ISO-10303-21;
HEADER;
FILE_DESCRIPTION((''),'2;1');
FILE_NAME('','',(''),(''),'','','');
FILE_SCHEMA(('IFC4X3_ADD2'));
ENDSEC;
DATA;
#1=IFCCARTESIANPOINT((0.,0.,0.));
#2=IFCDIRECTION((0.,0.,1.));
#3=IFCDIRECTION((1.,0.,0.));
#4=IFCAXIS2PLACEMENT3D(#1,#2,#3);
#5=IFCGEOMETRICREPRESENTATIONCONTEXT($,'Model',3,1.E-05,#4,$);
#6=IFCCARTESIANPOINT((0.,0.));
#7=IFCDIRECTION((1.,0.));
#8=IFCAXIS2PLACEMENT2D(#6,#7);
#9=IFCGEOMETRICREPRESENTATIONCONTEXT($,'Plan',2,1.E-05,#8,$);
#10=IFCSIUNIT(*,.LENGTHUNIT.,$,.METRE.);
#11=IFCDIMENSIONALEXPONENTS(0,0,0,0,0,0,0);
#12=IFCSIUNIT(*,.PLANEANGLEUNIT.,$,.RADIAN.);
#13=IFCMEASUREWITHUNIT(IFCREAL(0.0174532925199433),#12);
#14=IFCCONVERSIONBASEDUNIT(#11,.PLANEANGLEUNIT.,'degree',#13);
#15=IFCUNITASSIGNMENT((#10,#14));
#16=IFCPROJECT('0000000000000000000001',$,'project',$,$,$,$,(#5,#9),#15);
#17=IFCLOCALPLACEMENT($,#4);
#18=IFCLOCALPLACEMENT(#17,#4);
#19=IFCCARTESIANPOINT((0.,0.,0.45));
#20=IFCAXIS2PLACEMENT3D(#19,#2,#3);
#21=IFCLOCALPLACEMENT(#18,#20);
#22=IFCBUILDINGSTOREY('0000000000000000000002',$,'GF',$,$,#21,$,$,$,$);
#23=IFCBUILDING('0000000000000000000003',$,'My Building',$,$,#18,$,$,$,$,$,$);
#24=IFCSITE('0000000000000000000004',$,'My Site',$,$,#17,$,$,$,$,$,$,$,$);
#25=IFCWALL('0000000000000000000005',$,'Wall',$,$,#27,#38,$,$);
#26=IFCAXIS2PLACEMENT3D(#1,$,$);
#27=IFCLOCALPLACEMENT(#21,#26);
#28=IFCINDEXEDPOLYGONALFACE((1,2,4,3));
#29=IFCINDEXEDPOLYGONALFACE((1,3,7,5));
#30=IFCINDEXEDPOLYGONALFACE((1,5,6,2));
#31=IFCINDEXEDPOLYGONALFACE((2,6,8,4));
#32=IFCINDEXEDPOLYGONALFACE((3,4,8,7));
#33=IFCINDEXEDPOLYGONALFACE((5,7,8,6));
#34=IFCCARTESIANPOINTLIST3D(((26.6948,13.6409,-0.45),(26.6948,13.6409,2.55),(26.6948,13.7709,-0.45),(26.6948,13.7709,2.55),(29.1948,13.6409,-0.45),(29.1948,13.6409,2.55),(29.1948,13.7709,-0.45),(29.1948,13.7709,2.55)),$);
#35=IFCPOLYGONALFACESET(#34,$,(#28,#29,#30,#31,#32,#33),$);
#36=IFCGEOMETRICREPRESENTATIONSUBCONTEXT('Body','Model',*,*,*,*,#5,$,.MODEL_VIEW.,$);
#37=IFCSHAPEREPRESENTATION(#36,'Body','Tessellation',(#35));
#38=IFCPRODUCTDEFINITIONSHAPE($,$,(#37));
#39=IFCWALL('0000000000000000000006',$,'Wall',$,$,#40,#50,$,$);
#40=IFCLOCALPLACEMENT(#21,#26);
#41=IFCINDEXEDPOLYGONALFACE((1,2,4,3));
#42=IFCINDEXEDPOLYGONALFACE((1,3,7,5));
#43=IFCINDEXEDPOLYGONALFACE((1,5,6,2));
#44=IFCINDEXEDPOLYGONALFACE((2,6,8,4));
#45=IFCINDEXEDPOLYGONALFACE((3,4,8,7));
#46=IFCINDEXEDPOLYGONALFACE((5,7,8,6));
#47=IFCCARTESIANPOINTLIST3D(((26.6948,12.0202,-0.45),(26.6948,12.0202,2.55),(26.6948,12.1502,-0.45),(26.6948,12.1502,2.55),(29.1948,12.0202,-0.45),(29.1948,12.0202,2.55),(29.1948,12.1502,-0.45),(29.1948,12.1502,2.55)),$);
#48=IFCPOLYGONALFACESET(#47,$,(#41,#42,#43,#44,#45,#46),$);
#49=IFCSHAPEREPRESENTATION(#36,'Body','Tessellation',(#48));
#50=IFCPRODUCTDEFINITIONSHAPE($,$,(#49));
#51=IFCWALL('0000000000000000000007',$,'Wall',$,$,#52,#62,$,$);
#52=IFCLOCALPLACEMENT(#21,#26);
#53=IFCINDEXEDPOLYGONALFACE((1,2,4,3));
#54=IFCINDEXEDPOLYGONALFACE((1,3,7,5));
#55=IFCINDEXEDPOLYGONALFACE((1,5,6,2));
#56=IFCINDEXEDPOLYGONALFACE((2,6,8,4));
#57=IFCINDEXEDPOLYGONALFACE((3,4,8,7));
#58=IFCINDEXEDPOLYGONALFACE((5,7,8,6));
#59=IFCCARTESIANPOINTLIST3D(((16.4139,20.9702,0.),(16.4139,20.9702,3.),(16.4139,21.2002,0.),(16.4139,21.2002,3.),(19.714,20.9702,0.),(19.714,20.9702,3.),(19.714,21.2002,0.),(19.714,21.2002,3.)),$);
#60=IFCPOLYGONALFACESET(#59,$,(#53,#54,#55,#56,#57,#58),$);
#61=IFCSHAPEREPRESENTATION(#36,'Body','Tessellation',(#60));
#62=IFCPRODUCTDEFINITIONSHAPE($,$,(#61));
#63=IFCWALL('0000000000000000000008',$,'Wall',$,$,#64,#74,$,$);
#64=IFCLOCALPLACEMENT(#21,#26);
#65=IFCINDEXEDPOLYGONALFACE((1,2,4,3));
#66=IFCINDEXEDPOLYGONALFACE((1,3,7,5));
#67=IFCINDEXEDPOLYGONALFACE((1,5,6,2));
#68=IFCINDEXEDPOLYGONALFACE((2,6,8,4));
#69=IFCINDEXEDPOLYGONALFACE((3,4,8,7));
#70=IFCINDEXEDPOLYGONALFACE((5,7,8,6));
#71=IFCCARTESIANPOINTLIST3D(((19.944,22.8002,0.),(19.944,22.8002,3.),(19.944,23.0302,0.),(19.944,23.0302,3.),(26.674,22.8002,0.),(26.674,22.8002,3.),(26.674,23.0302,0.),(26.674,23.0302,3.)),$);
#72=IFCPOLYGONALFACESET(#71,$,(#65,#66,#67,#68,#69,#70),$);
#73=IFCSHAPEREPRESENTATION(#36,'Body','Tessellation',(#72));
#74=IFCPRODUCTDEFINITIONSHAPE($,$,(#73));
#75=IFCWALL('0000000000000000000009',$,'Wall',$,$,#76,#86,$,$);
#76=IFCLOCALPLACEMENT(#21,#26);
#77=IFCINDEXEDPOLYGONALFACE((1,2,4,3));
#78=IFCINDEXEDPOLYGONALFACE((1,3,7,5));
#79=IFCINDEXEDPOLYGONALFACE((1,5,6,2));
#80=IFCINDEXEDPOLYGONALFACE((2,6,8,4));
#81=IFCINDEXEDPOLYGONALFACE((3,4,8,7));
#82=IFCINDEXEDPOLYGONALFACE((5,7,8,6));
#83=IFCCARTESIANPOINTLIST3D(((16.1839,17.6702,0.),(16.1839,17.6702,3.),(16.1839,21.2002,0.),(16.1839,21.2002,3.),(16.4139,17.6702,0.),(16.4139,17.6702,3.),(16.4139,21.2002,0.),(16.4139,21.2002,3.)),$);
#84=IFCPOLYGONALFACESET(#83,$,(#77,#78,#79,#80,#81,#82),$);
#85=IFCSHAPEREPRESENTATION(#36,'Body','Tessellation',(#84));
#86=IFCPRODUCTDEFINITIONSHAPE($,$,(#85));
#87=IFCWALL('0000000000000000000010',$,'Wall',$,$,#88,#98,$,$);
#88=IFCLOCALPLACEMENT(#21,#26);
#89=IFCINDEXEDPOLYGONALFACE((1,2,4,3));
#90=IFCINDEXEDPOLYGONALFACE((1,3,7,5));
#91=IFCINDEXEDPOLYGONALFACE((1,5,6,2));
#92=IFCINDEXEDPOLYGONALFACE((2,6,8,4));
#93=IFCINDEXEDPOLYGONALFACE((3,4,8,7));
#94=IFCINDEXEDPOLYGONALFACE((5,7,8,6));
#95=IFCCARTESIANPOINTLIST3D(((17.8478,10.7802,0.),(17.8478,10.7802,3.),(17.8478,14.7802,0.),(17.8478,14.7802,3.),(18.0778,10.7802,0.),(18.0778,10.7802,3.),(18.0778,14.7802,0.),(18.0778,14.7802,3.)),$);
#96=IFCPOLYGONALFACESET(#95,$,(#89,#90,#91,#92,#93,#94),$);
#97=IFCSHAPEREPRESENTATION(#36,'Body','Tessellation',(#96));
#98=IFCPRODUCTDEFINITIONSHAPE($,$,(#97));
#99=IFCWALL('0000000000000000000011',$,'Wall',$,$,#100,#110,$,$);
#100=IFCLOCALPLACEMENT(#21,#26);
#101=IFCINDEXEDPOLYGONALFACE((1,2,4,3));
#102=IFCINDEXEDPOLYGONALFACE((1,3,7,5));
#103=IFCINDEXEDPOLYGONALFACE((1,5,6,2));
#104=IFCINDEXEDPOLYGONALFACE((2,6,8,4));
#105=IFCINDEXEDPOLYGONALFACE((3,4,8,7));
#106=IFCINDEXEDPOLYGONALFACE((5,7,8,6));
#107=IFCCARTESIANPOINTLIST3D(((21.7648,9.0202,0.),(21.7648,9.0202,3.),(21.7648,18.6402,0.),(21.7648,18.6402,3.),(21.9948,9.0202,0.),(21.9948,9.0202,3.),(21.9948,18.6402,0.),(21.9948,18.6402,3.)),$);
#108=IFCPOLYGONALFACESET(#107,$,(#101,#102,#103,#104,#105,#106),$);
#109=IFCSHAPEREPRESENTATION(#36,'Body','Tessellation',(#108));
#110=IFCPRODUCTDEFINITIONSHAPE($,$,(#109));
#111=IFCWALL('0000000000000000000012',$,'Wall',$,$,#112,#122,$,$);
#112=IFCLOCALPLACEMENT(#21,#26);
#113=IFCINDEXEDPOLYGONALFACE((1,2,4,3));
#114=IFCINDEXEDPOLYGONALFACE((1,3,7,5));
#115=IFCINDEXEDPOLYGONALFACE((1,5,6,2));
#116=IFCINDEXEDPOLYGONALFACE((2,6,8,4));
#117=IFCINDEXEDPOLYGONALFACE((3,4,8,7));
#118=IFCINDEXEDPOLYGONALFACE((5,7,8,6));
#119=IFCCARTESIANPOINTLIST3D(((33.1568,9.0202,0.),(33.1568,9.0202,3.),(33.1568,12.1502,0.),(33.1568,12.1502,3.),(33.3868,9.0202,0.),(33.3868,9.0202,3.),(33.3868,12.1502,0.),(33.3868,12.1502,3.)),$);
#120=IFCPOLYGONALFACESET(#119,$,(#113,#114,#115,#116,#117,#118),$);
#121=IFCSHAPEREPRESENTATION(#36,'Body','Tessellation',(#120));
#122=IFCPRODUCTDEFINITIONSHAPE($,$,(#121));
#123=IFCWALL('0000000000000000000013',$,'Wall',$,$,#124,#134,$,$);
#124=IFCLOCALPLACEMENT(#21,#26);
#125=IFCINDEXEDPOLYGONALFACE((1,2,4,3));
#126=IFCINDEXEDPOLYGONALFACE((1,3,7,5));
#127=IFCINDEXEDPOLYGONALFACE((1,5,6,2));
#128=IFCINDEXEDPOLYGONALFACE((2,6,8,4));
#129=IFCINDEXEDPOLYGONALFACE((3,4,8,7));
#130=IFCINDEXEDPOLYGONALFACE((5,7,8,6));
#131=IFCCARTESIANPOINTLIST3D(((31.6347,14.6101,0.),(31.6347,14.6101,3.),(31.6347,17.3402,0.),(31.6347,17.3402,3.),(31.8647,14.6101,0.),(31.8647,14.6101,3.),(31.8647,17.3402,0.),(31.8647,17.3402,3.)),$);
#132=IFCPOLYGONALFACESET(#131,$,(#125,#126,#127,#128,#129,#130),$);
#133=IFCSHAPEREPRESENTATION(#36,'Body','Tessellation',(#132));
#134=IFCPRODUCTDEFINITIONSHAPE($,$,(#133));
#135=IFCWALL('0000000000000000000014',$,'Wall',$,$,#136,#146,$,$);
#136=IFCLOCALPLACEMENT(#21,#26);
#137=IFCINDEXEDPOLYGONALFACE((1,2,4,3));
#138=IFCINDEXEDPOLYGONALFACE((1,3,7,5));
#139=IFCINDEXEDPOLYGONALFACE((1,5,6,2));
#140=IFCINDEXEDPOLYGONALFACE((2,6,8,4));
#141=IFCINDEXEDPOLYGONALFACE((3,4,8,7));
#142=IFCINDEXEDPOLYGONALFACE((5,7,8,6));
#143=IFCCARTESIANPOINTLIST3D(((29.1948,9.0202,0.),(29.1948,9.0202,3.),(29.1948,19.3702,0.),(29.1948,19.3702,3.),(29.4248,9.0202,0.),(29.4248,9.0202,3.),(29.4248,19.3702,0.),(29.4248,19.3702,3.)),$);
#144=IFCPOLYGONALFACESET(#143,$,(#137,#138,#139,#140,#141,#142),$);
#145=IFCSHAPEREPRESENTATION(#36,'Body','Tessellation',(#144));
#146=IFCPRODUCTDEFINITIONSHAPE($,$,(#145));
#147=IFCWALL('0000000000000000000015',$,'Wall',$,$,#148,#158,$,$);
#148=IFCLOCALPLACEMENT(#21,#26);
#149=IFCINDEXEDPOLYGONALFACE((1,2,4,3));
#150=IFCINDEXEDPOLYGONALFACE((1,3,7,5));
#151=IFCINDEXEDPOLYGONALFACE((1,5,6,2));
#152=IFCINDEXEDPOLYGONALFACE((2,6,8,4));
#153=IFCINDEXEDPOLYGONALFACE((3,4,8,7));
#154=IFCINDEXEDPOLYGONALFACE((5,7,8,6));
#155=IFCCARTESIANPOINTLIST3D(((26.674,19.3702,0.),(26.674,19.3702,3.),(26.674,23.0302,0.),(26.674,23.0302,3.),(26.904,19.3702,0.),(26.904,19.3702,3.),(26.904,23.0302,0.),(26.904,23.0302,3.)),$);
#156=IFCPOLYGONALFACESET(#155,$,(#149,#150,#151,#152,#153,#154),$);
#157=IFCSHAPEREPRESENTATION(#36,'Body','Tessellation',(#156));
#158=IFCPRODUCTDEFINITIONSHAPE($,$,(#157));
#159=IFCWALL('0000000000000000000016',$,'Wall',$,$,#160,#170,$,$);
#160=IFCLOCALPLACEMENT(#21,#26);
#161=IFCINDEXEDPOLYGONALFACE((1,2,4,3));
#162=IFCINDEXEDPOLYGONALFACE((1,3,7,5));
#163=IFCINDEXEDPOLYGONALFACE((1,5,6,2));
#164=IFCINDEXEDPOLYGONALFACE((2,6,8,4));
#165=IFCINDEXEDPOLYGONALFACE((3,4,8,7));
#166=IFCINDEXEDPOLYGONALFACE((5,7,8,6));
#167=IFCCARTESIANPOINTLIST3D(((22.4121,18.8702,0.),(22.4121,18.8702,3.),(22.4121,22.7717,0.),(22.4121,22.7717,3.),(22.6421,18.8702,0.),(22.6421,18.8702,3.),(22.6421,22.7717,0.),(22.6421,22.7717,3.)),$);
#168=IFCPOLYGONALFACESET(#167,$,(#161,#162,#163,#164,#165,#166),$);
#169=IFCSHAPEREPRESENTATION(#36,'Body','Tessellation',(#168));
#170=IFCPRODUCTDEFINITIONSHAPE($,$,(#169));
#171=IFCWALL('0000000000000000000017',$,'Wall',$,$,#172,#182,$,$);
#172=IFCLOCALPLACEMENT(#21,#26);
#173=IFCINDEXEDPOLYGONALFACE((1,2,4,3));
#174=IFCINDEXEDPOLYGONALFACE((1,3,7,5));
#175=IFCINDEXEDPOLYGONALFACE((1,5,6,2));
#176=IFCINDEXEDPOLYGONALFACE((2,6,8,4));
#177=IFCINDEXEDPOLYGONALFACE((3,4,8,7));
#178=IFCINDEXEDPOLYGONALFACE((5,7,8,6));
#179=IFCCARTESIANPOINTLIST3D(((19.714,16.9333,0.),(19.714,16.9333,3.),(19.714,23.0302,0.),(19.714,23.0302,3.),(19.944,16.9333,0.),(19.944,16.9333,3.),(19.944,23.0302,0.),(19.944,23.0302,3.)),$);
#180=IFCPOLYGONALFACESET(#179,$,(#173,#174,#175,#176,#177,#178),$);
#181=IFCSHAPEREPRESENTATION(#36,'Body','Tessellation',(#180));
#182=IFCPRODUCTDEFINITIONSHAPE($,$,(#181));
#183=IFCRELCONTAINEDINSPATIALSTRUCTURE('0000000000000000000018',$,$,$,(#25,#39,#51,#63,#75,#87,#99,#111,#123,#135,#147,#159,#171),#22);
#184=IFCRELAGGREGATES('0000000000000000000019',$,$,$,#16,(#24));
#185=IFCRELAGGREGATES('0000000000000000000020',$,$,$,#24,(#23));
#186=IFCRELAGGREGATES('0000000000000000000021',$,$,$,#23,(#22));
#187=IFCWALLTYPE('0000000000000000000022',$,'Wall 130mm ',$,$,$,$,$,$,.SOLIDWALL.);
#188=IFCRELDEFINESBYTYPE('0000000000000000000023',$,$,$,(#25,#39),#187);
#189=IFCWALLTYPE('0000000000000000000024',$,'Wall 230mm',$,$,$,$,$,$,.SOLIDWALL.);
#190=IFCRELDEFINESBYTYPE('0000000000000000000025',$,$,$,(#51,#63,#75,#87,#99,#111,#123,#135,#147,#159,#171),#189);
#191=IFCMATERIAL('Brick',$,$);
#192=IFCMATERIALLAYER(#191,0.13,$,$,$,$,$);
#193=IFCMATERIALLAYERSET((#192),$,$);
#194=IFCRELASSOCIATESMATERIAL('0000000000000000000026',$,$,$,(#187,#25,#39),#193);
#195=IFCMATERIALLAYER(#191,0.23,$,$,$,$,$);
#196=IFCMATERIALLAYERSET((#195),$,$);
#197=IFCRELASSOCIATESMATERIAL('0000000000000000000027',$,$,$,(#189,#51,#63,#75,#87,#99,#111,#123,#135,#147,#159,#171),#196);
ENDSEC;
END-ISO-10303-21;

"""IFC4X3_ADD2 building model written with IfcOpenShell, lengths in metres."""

from ifc_helpers import new_model, entity, si_unit, converted_unit, frame, origin_with_axes, origin_2d_with_axis, place, context, subcontext, project, spatial, indexed_curve, outline, extrude, material, layer, layer_set, layer_usage, type_object, element, save


model = new_model("IFC4X3_ADD2")

# Units and contexts
model_context = context("Model", 3, precision=1e-05, world=origin_with_axes())
plan_context = context("Plan", 2, precision=1e-05, world=origin_2d_with_axis())
body_context = subcontext(model_context, "Body", "Model", "MODEL_VIEW")
ifc_project = project(units=[si_unit("LENGTHUNIT", "METRE"), converted_unit("PLANEANGLEUNIT", "degree", entity("IfcReal", 0.0174532925199433), si_unit("PLANEANGLEUNIT", "RADIAN"), dimensions=[0, 0, 0, 0, 0, 0, 0])], contexts=[model_context, plan_context])

# Site, building, storey
site_placement = place(None, origin_with_axes())
site = spatial("IfcSite", under=ifc_project, at=site_placement, Name="My Site")
building_placement = place(site_placement, origin_with_axes())
building = spatial("IfcBuilding", under=site, at=building_placement, Name="My Building")
storey_placement = place(building_placement, frame((0.0, 0.0, 0.45), z_axis=(0.0, 0.0, 1.0), x_axis=(1.0, 0.0, 0.0)))
storey = spatial("IfcBuildingStorey", under=building, at=storey_placement, Name="GF")

# Walls
ifc_material_1 = material(Name="Brick")
ifc_layer_1 = layer(ifc_material_1, 0.13)
ifc_layer_set_1 = layer_set([ifc_layer_1])
ifc_layer_usage_1 = layer_usage(ifc_layer_set_1, "AXIS2", "POSITIVE", 0.0)
wall_type_1 = type_object("IfcWallType", Name="Wall 130mm ", PredefinedType="SOLIDWALL", material=ifc_layer_set_1)
wall_1_placement = place(storey_placement, frame((29.1948, 13.7709, -0.45), z_axis=(0.0, 0.0, 1.0), x_axis=(-1.0, 0.0, 0.0)))
element("IfcWall", 1, at=wall_1_placement, inside=storey, type_object=wall_type_1, material=ifc_layer_usage_1, Name="Wall", context=body_context, shape_type="SweptSolid", body=[
    extrude(outline(indexed_curve([(0.0, 0.0), (0.0, 0.13), (2.5, 0.13), (2.5, 0.0), (0.0, 0.0)], self_intersect=False)), origin_with_axes(), (0.0, 0.0, 1.0), 3.0),
])
ifc_layer_usage_2 = layer_usage(ifc_layer_set_1, "AXIS2", "POSITIVE", 0.0)
wall_2_placement = place(storey_placement, frame((29.1948, 12.1502, -0.45), z_axis=(0.0, 0.0, 1.0), x_axis=(-1.0, 0.0, 0.0)))
element("IfcWall", 2, at=wall_2_placement, inside=storey, type_object=wall_type_1, material=ifc_layer_usage_2, Name="Wall", context=body_context, shape_type="SweptSolid", body=[
    extrude(outline(indexed_curve([(0.0, 0.0), (0.0, 0.13), (2.5, 0.13), (2.5, 0.0), (0.0, 0.0)], self_intersect=False)), origin_with_axes(), (0.0, 0.0, 1.0), 3.0),
])
ifc_layer_2 = layer(ifc_material_1, 0.23)
ifc_layer_set_2 = layer_set([ifc_layer_2])
ifc_layer_usage_3 = layer_usage(ifc_layer_set_2, "AXIS2", "POSITIVE", 0.0)
wall_type_2 = type_object("IfcWallType", Name="Wall 230mm", PredefinedType="SOLIDWALL", material=ifc_layer_set_2)
wall_3_placement = place(storey_placement, frame((19.714, 21.2002, 0.0), z_axis=(0.0, 0.0, 1.0), x_axis=(-1.0, 0.0, 0.0)))
element("IfcWall", 3, at=wall_3_placement, inside=storey, type_object=wall_type_2, material=ifc_layer_usage_3, Name="Wall", context=body_context, shape_type="SweptSolid", body=[
    extrude(outline(indexed_curve([(0.0, 0.0), (0.0, 0.23), (3.3, 0.23), (3.3, 0.0), (0.0, 0.0)], self_intersect=False)), origin_with_axes(), (0.0, 0.0, 1.0), 3.0),
])
ifc_layer_usage_4 = layer_usage(ifc_layer_set_2, "AXIS2", "POSITIVE", 0.0)
wall_4_placement = place(storey_placement, frame((26.674, 23.0302, 0.0), z_axis=(0.0, 0.0, 1.0), x_axis=(-1.0, 0.0, 0.0)))
element("IfcWall", 4, at=wall_4_placement, inside=storey, type_object=wall_type_2, material=ifc_layer_usage_4, Name="Wall", context=body_context, shape_type="SweptSolid", body=[
    extrude(outline(indexed_curve([(0.0, 0.0), (0.0, 0.23), (6.73, 0.23), (6.73, 0.0), (0.0, 0.0)], self_intersect=False)), origin_with_axes(), (0.0, 0.0, 1.0), 3.0),
])
ifc_layer_usage_5 = layer_usage(ifc_layer_set_2, "AXIS2", "POSITIVE", 0.0)
wall_5_placement = place(storey_placement, frame((16.4139, 17.6702, 0.0), z_axis=(0.0, 0.0, 1.0), x_axis=(0.000001, 1.0, 0.0)))
element("IfcWall", 5, at=wall_5_placement, inside=storey, type_object=wall_type_2, material=ifc_layer_usage_5, Name="Wall", context=body_context, shape_type="SweptSolid", body=[
    extrude(outline(indexed_curve([(0.0, 0.0), (0.0, 0.23), (3.53, 0.23), (3.53, 0.0), (0.0, 0.0)], self_intersect=False)), origin_with_axes(), (0.0, 0.0, 1.0), 3.0),
])
ifc_layer_usage_6 = layer_usage(ifc_layer_set_2, "AXIS2", "POSITIVE", 0.0)
wall_6_placement = place(storey_placement, frame((18.0778, 10.7802, 0.0), z_axis=(0.0, 0.0, 1.0), x_axis=(0.000001, 1.0, 0.0)))
element("IfcWall", 6, at=wall_6_placement, inside=storey, type_object=wall_type_2, material=ifc_layer_usage_6, Name="Wall", context=body_context, shape_type="SweptSolid", body=[
    extrude(outline(indexed_curve([(0.0, 0.0), (0.0, 0.23), (4.0, 0.23), (4.0, 0.0), (0.0, 0.0)], self_intersect=False)), origin_with_axes(), (0.0, 0.0, 1.0), 3.0),
])
ifc_layer_usage_7 = layer_usage(ifc_layer_set_2, "AXIS2", "POSITIVE", 0.0)
wall_7_placement = place(storey_placement, frame((21.9948, 9.0202, 0.0), z_axis=(0.0, 0.0, 1.0), x_axis=(0.000001, 1.0, 0.0)))
element("IfcWall", 7, at=wall_7_placement, inside=storey, type_object=wall_type_2, material=ifc_layer_usage_7, Name="Wall", context=body_context, shape_type="SweptSolid", body=[
    extrude(outline(indexed_curve([(0.0, 0.0), (0.0, 0.23), (9.62, 0.23), (9.62, 0.0), (0.0, 0.0)], self_intersect=False)), origin_with_axes(), (0.0, 0.0, 1.0), 3.0),
])
ifc_layer_usage_8 = layer_usage(ifc_layer_set_2, "AXIS2", "POSITIVE", 0.0)
wall_8_placement = place(storey_placement, frame((33.3868, 9.0202, 0.0), z_axis=(0.0, 0.0, 1.0), x_axis=(0.000001, 1.0, 0.0)))
element("IfcWall", 8, at=wall_8_placement, inside=storey, type_object=wall_type_2, material=ifc_layer_usage_8, Name="Wall", context=body_context, shape_type="SweptSolid", body=[
    extrude(outline(indexed_curve([(0.0, 0.0), (0.0, 0.23), (3.13, 0.23), (3.13, 0.0), (0.0, 0.0)], self_intersect=False)), origin_with_axes(), (0.0, 0.0, 1.0), 3.0),
])
ifc_layer_usage_9 = layer_usage(ifc_layer_set_2, "AXIS2", "POSITIVE", 0.0)
wall_9_placement = place(storey_placement, frame((31.8647, 14.6101, 0.0), z_axis=(0.0, 0.0, 1.0), x_axis=(0.000001, 1.0, 0.0)))
element("IfcWall", 9, at=wall_9_placement, inside=storey, type_object=wall_type_2, material=ifc_layer_usage_9, Name="Wall", context=body_context, shape_type="SweptSolid", body=[
    extrude(outline(indexed_curve([(0.0, 0.0), (0.0, 0.23), (2.73, 0.23), (2.73, 0.0), (0.0, 0.0)], self_intersect=False)), origin_with_axes(), (0.0, 0.0, 1.0), 3.0),
])
ifc_layer_usage_10 = layer_usage(ifc_layer_set_2, "AXIS2", "POSITIVE", 0.0)
wall_10_placement = place(storey_placement, frame((29.4248, 9.0202, 0.0), z_axis=(0.0, 0.0, 1.0), x_axis=(0.000001, 1.0, 0.0)))
element("IfcWall", 10, at=wall_10_placement, inside=storey, type_object=wall_type_2, material=ifc_layer_usage_10, Name="Wall", context=body_context, shape_type="SweptSolid", body=[
    extrude(outline(indexed_curve([(0.0, 0.0), (0.0, 0.23), (10.35, 0.23), (10.35, 0.0), (0.0, 0.0)], self_intersect=False)), origin_with_axes(), (0.0, 0.0, 1.0), 3.0),
])
ifc_layer_usage_11 = layer_usage(ifc_layer_set_2, "AXIS2", "POSITIVE", 0.0)
wall_11_placement = place(storey_placement, frame((26.904, 19.3702, 0.0), z_axis=(0.0, 0.0, 1.0), x_axis=(0.000001, 1.0, 0.0)))
element("IfcWall", 11, at=wall_11_placement, inside=storey, type_object=wall_type_2, material=ifc_layer_usage_11, Name="Wall", context=body_context, shape_type="SweptSolid", body=[
    extrude(outline(indexed_curve([(0.0, 0.0), (0.0, 0.23), (3.66, 0.23), (3.66, 0.0), (0.0, 0.0)], self_intersect=False)), origin_with_axes(), (0.0, 0.0, 1.0), 3.0),
])
ifc_layer_usage_12 = layer_usage(ifc_layer_set_2, "AXIS2", "POSITIVE", 0.0)
wall_12_placement = place(storey_placement, frame((22.6421, 18.8702, 0.0), z_axis=(0.0, 0.0, 1.0), x_axis=(0.000001, 1.0, 0.0)))
element("IfcWall", 12, at=wall_12_placement, inside=storey, type_object=wall_type_2, material=ifc_layer_usage_12, Name="Wall", context=body_context, shape_type="SweptSolid", body=[
    extrude(outline(indexed_curve([(0.0, 0.0), (0.0, 0.23), (3.9015, 0.23), (3.9015, 0.0), (0.0, 0.0)], self_intersect=False)), origin_with_axes(), (0.0, 0.0, 1.0), 3.0),
])
ifc_layer_usage_13 = layer_usage(ifc_layer_set_2, "AXIS2", "POSITIVE", 0.0)
wall_13_placement = place(storey_placement, frame((19.944, 16.9333, 0.0), z_axis=(0.0, 0.0, 1.0), x_axis=(0.000001, 1.0, 0.0)))
element("IfcWall", 13, at=wall_13_placement, inside=storey, type_object=wall_type_2, material=ifc_layer_usage_13, Name="Wall", context=body_context, shape_type="SweptSolid", body=[
    extrude(outline(indexed_curve([(0.0, 0.0), (0.0, 0.23), (6.0969, 0.23), (6.0969, 0.0), (0.0, 0.0)], self_intersect=False)), origin_with_axes(), (0.0, 0.0, 1.0), 3.0),
])

save(model, "model.ifc")
